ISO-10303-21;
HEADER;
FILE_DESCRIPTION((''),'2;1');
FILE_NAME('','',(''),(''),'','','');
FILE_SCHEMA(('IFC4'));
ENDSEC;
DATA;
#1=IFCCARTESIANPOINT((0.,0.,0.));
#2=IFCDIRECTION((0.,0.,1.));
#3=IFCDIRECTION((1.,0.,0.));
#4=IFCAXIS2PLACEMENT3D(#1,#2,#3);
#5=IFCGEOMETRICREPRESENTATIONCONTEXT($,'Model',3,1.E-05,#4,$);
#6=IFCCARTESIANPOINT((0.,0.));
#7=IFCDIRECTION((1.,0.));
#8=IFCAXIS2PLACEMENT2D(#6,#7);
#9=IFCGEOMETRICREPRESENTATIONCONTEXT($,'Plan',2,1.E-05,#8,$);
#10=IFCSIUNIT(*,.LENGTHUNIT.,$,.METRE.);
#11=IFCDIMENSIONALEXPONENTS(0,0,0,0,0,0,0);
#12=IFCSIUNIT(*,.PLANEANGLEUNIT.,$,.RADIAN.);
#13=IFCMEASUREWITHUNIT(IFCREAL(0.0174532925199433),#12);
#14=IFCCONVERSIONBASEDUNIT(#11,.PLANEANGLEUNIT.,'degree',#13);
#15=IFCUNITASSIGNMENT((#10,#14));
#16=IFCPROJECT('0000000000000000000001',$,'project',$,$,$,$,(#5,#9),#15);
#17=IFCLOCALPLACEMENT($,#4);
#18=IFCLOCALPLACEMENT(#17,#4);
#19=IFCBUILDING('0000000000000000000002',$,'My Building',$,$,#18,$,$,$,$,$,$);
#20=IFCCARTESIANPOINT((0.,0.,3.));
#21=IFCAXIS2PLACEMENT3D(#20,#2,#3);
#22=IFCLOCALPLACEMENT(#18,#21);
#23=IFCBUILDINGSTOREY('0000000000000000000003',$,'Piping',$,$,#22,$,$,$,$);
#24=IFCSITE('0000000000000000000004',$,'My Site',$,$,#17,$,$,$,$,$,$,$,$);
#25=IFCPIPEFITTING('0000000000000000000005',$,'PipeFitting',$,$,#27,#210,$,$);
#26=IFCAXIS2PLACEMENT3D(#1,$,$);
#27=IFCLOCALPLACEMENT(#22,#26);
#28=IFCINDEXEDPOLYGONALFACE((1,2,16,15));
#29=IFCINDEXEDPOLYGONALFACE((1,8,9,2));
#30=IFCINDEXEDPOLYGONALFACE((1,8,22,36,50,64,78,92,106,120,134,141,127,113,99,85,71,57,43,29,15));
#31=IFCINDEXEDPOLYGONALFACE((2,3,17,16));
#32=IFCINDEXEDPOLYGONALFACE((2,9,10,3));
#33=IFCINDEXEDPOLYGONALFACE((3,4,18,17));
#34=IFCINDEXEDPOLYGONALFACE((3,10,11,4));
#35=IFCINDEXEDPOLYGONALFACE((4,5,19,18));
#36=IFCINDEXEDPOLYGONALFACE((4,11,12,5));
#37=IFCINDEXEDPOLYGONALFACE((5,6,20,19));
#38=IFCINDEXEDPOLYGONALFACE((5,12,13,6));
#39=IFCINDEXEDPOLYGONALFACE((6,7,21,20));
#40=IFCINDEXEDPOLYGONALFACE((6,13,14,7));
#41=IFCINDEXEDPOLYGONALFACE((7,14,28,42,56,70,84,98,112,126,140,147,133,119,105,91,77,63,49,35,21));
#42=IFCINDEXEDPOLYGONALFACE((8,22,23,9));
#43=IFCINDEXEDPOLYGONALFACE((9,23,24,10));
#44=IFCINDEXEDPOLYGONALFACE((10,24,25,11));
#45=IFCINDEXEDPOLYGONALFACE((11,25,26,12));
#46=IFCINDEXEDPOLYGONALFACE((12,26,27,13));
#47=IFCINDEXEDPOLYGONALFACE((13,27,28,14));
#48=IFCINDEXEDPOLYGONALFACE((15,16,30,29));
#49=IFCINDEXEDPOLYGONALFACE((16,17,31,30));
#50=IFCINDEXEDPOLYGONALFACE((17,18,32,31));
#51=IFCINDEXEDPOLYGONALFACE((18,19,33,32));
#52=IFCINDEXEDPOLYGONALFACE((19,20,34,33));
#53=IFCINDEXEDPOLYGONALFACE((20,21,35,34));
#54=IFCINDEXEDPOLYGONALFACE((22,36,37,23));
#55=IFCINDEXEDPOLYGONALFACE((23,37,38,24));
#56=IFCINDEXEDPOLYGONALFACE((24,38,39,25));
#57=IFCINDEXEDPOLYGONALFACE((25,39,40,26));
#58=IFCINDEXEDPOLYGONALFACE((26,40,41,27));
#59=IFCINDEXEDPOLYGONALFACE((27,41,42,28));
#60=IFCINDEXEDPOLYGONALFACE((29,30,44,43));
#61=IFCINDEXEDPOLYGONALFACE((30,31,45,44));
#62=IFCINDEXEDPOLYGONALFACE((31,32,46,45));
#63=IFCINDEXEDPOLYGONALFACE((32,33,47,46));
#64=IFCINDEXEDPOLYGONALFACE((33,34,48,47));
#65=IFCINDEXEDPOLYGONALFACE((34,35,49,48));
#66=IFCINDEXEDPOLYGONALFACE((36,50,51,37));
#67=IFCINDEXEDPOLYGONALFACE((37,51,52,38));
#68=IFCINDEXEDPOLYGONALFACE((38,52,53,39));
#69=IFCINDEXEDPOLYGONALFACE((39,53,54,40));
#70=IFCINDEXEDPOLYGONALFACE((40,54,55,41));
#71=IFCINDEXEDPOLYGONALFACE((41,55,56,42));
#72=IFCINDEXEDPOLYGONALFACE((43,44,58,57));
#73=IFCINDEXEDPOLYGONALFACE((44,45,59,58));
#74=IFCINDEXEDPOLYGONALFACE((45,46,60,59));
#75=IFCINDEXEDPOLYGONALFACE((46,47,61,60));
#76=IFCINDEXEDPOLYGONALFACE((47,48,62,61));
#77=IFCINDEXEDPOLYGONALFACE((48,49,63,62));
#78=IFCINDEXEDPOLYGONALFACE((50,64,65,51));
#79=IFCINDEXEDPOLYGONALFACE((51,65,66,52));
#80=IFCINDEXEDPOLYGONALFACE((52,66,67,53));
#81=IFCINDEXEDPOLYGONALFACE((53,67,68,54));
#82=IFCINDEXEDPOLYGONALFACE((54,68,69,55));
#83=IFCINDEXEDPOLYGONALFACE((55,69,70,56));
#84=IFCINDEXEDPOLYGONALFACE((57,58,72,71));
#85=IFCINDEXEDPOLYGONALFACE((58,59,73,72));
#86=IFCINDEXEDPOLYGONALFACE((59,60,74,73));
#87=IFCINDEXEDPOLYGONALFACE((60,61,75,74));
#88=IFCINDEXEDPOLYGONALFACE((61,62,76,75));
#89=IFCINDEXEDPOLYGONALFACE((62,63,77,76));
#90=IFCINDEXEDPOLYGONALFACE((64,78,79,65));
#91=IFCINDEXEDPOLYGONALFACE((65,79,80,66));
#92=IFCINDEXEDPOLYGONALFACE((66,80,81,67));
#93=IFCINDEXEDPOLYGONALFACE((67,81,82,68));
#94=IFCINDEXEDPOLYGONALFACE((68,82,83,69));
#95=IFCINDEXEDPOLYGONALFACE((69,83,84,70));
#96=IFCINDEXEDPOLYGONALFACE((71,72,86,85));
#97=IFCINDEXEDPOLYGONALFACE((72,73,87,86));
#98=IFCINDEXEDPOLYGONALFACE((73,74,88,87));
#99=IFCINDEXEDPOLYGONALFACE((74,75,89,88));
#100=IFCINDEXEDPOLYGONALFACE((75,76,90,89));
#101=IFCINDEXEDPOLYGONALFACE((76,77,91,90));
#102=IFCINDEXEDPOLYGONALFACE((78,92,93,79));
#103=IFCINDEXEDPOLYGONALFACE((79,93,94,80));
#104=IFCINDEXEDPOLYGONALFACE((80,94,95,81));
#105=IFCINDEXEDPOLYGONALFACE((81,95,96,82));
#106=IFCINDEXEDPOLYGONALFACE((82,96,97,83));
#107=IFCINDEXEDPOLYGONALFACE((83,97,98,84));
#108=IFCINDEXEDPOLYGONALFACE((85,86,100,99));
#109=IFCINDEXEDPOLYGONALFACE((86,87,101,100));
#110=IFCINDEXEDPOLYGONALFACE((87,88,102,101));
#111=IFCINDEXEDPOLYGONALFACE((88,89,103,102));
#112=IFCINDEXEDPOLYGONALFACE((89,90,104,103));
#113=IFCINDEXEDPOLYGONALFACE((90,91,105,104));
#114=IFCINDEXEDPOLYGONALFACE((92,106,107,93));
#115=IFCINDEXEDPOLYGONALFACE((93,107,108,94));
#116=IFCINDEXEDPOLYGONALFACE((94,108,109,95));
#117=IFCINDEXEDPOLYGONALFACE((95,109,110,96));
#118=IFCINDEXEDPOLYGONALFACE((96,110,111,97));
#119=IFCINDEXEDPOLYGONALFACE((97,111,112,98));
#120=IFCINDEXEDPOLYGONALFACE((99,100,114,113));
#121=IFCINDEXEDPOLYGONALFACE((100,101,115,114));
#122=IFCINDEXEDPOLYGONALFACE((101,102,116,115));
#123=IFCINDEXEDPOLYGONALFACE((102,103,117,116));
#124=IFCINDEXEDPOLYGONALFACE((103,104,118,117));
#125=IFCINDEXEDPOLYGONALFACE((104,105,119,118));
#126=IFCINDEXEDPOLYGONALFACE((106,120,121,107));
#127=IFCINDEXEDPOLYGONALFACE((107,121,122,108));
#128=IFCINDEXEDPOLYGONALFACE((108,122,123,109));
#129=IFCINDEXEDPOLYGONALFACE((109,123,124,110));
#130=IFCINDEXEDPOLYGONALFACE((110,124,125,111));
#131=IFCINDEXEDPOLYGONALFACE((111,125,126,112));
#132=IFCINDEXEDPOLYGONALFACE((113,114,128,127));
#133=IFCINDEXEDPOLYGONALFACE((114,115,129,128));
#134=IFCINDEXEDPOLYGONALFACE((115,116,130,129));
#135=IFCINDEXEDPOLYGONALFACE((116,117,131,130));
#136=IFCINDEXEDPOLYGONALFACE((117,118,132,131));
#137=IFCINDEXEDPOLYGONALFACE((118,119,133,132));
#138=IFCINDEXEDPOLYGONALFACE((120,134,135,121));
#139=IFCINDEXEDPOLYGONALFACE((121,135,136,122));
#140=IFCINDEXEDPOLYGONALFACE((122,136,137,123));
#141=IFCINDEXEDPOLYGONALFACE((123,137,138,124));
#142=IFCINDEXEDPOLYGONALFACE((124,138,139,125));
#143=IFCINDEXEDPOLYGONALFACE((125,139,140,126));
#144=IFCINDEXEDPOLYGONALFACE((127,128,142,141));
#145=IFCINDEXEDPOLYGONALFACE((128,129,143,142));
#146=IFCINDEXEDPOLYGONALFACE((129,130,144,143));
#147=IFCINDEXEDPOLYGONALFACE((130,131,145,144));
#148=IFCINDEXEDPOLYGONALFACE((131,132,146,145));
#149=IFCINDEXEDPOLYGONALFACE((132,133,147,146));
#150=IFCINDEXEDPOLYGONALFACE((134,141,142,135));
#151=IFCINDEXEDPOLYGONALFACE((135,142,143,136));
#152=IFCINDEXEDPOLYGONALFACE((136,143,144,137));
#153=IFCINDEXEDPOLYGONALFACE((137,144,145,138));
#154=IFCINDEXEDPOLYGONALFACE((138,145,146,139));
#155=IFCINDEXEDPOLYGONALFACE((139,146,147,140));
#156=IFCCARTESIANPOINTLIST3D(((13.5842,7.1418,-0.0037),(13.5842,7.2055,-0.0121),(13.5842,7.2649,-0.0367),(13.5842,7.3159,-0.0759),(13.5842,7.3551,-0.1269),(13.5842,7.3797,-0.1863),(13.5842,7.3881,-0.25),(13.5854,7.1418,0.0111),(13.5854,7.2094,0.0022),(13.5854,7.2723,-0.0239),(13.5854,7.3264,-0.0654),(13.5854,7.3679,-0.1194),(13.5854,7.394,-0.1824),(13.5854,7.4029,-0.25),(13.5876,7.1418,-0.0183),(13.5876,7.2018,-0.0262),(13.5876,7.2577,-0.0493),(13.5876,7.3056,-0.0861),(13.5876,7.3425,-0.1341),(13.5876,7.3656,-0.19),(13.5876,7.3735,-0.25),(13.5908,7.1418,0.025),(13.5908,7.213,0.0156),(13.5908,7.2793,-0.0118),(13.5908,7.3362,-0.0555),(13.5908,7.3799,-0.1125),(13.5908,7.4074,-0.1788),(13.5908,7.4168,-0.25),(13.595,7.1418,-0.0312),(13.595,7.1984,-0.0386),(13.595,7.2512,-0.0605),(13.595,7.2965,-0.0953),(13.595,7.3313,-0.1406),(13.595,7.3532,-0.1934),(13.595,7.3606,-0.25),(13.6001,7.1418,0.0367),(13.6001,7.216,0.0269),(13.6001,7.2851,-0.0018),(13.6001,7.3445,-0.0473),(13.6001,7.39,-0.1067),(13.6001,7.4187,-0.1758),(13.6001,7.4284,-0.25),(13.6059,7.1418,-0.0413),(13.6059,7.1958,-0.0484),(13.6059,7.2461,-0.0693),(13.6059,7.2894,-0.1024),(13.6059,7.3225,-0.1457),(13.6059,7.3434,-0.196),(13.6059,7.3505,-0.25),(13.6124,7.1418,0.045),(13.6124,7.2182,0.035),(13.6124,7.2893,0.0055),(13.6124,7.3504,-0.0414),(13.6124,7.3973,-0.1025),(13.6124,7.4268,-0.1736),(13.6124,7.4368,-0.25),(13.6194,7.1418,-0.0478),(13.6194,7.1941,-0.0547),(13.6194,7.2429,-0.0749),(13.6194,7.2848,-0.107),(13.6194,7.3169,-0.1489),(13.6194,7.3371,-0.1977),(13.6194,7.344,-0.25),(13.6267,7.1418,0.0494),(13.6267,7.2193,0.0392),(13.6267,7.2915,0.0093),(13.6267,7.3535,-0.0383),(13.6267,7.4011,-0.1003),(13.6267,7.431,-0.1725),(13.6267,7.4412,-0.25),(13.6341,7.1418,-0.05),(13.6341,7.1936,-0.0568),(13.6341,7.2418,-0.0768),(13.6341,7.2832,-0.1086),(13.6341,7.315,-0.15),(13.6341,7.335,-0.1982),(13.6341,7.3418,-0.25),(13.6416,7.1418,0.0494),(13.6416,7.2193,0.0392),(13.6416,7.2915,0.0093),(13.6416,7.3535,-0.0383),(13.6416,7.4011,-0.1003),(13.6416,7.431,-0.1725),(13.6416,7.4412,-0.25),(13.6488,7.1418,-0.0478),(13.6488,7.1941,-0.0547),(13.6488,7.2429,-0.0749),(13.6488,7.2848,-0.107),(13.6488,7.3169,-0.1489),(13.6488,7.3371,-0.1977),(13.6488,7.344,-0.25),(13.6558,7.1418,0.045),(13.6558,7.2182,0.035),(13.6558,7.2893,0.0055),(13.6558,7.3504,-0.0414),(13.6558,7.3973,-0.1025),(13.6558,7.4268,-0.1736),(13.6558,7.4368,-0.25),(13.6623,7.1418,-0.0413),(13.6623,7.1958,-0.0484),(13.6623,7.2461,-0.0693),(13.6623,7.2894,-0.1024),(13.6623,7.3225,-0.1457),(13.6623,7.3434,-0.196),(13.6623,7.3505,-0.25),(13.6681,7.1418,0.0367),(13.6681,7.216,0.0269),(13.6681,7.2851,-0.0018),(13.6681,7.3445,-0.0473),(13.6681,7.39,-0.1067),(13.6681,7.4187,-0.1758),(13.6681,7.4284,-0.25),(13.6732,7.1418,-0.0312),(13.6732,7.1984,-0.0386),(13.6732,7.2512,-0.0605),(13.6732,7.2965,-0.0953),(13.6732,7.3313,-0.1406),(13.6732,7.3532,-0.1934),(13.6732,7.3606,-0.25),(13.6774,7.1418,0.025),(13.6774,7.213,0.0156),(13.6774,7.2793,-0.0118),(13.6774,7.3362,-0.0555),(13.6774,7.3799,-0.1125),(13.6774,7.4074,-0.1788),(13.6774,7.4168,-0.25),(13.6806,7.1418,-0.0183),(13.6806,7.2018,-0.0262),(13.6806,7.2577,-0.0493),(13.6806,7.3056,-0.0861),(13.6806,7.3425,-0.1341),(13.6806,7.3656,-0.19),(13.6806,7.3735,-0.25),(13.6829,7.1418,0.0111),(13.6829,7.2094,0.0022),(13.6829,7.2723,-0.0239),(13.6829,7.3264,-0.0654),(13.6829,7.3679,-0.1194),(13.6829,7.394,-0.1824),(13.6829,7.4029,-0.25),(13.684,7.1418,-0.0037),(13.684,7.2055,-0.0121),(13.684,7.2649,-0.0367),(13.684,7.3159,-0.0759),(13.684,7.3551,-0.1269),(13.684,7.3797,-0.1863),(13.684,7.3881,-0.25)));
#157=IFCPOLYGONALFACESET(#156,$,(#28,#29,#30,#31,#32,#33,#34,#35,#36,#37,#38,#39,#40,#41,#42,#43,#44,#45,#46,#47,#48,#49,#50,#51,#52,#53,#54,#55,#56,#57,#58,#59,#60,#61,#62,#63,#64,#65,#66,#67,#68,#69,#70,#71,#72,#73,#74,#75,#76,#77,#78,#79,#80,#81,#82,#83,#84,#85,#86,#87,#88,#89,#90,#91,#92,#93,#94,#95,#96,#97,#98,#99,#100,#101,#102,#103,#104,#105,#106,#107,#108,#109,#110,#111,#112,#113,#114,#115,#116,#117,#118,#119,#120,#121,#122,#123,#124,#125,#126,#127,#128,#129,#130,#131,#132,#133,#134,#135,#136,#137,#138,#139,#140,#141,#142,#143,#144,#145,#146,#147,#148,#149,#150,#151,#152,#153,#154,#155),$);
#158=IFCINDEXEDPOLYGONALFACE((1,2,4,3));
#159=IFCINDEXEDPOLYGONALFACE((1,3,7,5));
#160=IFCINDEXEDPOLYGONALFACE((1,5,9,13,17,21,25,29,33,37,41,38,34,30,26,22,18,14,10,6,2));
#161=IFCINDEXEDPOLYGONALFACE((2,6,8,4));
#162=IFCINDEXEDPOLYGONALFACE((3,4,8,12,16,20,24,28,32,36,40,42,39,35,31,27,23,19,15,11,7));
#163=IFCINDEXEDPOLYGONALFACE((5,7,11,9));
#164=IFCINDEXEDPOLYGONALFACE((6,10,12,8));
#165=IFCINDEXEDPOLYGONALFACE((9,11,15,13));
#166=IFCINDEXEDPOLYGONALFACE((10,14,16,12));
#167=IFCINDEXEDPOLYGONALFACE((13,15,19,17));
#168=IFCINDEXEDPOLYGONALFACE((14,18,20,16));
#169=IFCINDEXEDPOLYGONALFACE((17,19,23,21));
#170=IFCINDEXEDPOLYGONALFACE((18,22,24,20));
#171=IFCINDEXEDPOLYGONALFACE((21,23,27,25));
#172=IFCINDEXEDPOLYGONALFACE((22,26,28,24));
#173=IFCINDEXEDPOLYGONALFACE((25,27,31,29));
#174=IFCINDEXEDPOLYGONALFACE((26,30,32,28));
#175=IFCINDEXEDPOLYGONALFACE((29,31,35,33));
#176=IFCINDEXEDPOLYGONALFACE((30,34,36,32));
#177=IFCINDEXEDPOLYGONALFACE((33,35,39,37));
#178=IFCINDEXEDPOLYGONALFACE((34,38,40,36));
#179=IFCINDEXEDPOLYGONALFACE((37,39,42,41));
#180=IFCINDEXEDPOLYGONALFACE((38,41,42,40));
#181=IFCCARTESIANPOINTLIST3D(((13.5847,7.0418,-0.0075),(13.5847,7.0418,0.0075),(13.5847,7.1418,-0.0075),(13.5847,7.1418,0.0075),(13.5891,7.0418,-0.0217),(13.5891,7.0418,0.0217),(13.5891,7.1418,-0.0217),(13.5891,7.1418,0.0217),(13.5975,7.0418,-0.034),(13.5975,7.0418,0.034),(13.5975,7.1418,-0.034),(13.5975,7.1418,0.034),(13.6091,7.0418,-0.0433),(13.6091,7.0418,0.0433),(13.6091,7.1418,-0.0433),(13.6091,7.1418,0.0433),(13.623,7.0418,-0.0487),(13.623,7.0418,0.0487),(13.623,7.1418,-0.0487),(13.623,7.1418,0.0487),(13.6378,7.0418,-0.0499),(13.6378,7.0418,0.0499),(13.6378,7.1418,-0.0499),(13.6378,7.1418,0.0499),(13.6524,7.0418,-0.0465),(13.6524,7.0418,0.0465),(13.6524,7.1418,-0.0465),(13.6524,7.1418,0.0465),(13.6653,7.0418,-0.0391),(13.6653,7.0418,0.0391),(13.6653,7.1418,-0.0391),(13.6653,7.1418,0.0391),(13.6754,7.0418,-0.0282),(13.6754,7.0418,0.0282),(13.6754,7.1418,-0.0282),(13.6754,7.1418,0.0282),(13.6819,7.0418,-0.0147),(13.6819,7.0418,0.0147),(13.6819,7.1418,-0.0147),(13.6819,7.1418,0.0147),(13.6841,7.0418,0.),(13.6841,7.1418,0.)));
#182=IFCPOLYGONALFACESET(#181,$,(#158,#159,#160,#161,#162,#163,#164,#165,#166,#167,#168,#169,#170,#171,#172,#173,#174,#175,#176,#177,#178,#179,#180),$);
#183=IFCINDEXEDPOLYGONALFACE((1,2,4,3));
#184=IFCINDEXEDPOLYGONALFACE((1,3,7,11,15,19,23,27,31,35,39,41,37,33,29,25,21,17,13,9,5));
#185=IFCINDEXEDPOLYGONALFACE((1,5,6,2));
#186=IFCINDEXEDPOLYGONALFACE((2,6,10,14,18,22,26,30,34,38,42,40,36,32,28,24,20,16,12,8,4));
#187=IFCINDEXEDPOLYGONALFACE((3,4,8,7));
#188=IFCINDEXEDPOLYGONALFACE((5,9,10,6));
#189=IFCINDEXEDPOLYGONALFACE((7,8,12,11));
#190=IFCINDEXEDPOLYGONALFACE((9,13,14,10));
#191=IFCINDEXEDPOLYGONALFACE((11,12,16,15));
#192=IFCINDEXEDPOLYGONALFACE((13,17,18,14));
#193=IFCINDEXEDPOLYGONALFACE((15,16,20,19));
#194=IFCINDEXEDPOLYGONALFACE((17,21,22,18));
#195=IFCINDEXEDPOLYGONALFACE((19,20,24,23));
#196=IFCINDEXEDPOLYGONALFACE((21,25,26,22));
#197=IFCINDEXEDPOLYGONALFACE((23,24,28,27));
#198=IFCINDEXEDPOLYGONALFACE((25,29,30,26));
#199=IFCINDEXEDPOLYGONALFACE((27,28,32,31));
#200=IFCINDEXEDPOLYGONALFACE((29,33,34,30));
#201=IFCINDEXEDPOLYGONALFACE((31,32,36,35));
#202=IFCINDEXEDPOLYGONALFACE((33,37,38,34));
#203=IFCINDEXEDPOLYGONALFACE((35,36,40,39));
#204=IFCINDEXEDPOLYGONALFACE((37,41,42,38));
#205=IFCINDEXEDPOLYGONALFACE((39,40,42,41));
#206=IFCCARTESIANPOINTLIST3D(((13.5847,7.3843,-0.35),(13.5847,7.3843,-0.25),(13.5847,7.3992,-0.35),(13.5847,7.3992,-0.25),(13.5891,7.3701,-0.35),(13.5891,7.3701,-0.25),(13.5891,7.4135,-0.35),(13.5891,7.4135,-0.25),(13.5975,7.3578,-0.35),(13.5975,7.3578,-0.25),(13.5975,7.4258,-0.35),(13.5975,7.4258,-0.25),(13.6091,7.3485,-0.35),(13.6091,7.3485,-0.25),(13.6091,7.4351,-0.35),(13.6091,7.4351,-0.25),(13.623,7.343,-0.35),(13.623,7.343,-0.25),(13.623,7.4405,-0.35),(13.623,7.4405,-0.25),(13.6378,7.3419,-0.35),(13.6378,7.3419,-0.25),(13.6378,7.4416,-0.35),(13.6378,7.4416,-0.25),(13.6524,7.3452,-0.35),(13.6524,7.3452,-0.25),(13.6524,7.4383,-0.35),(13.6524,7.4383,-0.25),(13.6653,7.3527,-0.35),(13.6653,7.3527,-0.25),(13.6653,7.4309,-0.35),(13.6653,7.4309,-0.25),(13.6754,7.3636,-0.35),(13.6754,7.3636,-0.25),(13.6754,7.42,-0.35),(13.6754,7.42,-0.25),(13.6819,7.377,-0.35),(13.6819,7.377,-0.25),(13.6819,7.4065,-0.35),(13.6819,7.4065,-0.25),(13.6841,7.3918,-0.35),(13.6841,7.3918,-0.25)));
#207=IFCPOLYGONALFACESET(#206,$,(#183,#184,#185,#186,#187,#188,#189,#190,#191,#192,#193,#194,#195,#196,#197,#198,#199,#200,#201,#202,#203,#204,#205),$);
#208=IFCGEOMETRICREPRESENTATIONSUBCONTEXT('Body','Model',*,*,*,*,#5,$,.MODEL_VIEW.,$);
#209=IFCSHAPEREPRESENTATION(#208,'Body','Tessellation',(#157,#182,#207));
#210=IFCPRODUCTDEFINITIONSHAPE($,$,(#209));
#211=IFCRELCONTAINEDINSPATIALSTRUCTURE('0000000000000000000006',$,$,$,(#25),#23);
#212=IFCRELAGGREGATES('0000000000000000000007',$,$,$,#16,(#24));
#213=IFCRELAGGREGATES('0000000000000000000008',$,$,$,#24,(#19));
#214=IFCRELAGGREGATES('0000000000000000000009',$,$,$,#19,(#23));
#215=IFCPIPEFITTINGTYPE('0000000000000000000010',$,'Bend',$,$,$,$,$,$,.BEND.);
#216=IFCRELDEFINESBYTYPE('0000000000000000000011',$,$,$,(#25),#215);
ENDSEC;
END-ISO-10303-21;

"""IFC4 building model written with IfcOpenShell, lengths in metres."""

from ifc_helpers import new_model, entity, si_unit, converted_unit, frame, origin_with_axes, origin_2d_with_axis, place, context, subcontext, project, spatial, circle, extrude, source, transform, mapped, type_object, type_shapes, element, save


model = new_model("IFC4")

# Units and contexts
model_context = context("Model", 3, precision=1e-05, world=origin_with_axes())
plan_context = context("Plan", 2, precision=1e-05, world=origin_2d_with_axis())
body_context = subcontext(model_context, "Body", "Model", "MODEL_VIEW")
ifc_project = project(units=[si_unit("LENGTHUNIT", "METRE"), converted_unit("PLANEANGLEUNIT", "degree", entity("IfcReal", 0.0174532925199433), si_unit("PLANEANGLEUNIT", "RADIAN"), dimensions=[0, 0, 0, 0, 0, 0, 0])], contexts=[model_context, plan_context])

# Site, building, storey
site_placement = place(None, origin_with_axes())
site = spatial("IfcSite", under=ifc_project, at=site_placement, Name="My Site")
building_placement = place(site_placement, origin_with_axes())
building = spatial("IfcBuilding", under=site, at=building_placement, Name="My Building")
storey_placement = place(building_placement, frame((0.0, 0.0, 3.0), z_axis=(0.0, 0.0, 1.0), x_axis=(1.0, 0.0, 0.0)))
storey = spatial("IfcBuildingStorey", under=building, at=storey_placement, Name="Piping")

# Pipe fitting
pipe_fitting_type = type_object("IfcPipeFittingType", Name="Bend", PredefinedType="BEND")
shared_shape = source(origin_with_axes(), body_context, "Body", "SolidModel", [
    entity("IfcSweptDiskSolid", entity("IfcIndexedPolyCurve", entity("IfcCartesianPointList3D", [[0.0, 0.0, -0.1], [0.0, -0.0732, -0.2768], [0.0, -0.25, -0.35]]), [entity("IfcArcIndex", [1, 2, 3])]), 0.05),
    extrude(circle(Radius=0.05), origin_with_axes(), (0.0, 0.0, -1.0), 0.1),
    extrude(circle(Radius=0.05), frame((0.0, -0.25, -0.35), z_axis=(0.0, -1.0, 0.0), x_axis=(1.0, 0.0, 0.0)), (0.0, 0.0, 1.0), 0.1),
])
type_shapes(pipe_fitting_type, [shared_shape])
for number, where, z_axis, x_axis, name in (
    (1, (13.6341, 7.0418, 0.0), (0.0, -1.0, 0.0), (1.0, 0.0, 0.0), "PipeFitting"),
):
    element("IfcPipeFitting", number, at=place(storey_placement, frame(where, z_axis=z_axis, x_axis=x_axis)), inside=storey, type_object=pipe_fitting_type, Name=name, context=body_context, shape_type="MappedRepresentation", body=[
        mapped(shared_shape, transform((0.0, 0.0, 0.0), x_axis=(1.0, 0.0, 0.0), y_axis=(0.0, 1.0, 0.0), z_axis=(0.0, 0.0, 1.0), scale=1.0)),
    ])

save(model, "model.ifc")
